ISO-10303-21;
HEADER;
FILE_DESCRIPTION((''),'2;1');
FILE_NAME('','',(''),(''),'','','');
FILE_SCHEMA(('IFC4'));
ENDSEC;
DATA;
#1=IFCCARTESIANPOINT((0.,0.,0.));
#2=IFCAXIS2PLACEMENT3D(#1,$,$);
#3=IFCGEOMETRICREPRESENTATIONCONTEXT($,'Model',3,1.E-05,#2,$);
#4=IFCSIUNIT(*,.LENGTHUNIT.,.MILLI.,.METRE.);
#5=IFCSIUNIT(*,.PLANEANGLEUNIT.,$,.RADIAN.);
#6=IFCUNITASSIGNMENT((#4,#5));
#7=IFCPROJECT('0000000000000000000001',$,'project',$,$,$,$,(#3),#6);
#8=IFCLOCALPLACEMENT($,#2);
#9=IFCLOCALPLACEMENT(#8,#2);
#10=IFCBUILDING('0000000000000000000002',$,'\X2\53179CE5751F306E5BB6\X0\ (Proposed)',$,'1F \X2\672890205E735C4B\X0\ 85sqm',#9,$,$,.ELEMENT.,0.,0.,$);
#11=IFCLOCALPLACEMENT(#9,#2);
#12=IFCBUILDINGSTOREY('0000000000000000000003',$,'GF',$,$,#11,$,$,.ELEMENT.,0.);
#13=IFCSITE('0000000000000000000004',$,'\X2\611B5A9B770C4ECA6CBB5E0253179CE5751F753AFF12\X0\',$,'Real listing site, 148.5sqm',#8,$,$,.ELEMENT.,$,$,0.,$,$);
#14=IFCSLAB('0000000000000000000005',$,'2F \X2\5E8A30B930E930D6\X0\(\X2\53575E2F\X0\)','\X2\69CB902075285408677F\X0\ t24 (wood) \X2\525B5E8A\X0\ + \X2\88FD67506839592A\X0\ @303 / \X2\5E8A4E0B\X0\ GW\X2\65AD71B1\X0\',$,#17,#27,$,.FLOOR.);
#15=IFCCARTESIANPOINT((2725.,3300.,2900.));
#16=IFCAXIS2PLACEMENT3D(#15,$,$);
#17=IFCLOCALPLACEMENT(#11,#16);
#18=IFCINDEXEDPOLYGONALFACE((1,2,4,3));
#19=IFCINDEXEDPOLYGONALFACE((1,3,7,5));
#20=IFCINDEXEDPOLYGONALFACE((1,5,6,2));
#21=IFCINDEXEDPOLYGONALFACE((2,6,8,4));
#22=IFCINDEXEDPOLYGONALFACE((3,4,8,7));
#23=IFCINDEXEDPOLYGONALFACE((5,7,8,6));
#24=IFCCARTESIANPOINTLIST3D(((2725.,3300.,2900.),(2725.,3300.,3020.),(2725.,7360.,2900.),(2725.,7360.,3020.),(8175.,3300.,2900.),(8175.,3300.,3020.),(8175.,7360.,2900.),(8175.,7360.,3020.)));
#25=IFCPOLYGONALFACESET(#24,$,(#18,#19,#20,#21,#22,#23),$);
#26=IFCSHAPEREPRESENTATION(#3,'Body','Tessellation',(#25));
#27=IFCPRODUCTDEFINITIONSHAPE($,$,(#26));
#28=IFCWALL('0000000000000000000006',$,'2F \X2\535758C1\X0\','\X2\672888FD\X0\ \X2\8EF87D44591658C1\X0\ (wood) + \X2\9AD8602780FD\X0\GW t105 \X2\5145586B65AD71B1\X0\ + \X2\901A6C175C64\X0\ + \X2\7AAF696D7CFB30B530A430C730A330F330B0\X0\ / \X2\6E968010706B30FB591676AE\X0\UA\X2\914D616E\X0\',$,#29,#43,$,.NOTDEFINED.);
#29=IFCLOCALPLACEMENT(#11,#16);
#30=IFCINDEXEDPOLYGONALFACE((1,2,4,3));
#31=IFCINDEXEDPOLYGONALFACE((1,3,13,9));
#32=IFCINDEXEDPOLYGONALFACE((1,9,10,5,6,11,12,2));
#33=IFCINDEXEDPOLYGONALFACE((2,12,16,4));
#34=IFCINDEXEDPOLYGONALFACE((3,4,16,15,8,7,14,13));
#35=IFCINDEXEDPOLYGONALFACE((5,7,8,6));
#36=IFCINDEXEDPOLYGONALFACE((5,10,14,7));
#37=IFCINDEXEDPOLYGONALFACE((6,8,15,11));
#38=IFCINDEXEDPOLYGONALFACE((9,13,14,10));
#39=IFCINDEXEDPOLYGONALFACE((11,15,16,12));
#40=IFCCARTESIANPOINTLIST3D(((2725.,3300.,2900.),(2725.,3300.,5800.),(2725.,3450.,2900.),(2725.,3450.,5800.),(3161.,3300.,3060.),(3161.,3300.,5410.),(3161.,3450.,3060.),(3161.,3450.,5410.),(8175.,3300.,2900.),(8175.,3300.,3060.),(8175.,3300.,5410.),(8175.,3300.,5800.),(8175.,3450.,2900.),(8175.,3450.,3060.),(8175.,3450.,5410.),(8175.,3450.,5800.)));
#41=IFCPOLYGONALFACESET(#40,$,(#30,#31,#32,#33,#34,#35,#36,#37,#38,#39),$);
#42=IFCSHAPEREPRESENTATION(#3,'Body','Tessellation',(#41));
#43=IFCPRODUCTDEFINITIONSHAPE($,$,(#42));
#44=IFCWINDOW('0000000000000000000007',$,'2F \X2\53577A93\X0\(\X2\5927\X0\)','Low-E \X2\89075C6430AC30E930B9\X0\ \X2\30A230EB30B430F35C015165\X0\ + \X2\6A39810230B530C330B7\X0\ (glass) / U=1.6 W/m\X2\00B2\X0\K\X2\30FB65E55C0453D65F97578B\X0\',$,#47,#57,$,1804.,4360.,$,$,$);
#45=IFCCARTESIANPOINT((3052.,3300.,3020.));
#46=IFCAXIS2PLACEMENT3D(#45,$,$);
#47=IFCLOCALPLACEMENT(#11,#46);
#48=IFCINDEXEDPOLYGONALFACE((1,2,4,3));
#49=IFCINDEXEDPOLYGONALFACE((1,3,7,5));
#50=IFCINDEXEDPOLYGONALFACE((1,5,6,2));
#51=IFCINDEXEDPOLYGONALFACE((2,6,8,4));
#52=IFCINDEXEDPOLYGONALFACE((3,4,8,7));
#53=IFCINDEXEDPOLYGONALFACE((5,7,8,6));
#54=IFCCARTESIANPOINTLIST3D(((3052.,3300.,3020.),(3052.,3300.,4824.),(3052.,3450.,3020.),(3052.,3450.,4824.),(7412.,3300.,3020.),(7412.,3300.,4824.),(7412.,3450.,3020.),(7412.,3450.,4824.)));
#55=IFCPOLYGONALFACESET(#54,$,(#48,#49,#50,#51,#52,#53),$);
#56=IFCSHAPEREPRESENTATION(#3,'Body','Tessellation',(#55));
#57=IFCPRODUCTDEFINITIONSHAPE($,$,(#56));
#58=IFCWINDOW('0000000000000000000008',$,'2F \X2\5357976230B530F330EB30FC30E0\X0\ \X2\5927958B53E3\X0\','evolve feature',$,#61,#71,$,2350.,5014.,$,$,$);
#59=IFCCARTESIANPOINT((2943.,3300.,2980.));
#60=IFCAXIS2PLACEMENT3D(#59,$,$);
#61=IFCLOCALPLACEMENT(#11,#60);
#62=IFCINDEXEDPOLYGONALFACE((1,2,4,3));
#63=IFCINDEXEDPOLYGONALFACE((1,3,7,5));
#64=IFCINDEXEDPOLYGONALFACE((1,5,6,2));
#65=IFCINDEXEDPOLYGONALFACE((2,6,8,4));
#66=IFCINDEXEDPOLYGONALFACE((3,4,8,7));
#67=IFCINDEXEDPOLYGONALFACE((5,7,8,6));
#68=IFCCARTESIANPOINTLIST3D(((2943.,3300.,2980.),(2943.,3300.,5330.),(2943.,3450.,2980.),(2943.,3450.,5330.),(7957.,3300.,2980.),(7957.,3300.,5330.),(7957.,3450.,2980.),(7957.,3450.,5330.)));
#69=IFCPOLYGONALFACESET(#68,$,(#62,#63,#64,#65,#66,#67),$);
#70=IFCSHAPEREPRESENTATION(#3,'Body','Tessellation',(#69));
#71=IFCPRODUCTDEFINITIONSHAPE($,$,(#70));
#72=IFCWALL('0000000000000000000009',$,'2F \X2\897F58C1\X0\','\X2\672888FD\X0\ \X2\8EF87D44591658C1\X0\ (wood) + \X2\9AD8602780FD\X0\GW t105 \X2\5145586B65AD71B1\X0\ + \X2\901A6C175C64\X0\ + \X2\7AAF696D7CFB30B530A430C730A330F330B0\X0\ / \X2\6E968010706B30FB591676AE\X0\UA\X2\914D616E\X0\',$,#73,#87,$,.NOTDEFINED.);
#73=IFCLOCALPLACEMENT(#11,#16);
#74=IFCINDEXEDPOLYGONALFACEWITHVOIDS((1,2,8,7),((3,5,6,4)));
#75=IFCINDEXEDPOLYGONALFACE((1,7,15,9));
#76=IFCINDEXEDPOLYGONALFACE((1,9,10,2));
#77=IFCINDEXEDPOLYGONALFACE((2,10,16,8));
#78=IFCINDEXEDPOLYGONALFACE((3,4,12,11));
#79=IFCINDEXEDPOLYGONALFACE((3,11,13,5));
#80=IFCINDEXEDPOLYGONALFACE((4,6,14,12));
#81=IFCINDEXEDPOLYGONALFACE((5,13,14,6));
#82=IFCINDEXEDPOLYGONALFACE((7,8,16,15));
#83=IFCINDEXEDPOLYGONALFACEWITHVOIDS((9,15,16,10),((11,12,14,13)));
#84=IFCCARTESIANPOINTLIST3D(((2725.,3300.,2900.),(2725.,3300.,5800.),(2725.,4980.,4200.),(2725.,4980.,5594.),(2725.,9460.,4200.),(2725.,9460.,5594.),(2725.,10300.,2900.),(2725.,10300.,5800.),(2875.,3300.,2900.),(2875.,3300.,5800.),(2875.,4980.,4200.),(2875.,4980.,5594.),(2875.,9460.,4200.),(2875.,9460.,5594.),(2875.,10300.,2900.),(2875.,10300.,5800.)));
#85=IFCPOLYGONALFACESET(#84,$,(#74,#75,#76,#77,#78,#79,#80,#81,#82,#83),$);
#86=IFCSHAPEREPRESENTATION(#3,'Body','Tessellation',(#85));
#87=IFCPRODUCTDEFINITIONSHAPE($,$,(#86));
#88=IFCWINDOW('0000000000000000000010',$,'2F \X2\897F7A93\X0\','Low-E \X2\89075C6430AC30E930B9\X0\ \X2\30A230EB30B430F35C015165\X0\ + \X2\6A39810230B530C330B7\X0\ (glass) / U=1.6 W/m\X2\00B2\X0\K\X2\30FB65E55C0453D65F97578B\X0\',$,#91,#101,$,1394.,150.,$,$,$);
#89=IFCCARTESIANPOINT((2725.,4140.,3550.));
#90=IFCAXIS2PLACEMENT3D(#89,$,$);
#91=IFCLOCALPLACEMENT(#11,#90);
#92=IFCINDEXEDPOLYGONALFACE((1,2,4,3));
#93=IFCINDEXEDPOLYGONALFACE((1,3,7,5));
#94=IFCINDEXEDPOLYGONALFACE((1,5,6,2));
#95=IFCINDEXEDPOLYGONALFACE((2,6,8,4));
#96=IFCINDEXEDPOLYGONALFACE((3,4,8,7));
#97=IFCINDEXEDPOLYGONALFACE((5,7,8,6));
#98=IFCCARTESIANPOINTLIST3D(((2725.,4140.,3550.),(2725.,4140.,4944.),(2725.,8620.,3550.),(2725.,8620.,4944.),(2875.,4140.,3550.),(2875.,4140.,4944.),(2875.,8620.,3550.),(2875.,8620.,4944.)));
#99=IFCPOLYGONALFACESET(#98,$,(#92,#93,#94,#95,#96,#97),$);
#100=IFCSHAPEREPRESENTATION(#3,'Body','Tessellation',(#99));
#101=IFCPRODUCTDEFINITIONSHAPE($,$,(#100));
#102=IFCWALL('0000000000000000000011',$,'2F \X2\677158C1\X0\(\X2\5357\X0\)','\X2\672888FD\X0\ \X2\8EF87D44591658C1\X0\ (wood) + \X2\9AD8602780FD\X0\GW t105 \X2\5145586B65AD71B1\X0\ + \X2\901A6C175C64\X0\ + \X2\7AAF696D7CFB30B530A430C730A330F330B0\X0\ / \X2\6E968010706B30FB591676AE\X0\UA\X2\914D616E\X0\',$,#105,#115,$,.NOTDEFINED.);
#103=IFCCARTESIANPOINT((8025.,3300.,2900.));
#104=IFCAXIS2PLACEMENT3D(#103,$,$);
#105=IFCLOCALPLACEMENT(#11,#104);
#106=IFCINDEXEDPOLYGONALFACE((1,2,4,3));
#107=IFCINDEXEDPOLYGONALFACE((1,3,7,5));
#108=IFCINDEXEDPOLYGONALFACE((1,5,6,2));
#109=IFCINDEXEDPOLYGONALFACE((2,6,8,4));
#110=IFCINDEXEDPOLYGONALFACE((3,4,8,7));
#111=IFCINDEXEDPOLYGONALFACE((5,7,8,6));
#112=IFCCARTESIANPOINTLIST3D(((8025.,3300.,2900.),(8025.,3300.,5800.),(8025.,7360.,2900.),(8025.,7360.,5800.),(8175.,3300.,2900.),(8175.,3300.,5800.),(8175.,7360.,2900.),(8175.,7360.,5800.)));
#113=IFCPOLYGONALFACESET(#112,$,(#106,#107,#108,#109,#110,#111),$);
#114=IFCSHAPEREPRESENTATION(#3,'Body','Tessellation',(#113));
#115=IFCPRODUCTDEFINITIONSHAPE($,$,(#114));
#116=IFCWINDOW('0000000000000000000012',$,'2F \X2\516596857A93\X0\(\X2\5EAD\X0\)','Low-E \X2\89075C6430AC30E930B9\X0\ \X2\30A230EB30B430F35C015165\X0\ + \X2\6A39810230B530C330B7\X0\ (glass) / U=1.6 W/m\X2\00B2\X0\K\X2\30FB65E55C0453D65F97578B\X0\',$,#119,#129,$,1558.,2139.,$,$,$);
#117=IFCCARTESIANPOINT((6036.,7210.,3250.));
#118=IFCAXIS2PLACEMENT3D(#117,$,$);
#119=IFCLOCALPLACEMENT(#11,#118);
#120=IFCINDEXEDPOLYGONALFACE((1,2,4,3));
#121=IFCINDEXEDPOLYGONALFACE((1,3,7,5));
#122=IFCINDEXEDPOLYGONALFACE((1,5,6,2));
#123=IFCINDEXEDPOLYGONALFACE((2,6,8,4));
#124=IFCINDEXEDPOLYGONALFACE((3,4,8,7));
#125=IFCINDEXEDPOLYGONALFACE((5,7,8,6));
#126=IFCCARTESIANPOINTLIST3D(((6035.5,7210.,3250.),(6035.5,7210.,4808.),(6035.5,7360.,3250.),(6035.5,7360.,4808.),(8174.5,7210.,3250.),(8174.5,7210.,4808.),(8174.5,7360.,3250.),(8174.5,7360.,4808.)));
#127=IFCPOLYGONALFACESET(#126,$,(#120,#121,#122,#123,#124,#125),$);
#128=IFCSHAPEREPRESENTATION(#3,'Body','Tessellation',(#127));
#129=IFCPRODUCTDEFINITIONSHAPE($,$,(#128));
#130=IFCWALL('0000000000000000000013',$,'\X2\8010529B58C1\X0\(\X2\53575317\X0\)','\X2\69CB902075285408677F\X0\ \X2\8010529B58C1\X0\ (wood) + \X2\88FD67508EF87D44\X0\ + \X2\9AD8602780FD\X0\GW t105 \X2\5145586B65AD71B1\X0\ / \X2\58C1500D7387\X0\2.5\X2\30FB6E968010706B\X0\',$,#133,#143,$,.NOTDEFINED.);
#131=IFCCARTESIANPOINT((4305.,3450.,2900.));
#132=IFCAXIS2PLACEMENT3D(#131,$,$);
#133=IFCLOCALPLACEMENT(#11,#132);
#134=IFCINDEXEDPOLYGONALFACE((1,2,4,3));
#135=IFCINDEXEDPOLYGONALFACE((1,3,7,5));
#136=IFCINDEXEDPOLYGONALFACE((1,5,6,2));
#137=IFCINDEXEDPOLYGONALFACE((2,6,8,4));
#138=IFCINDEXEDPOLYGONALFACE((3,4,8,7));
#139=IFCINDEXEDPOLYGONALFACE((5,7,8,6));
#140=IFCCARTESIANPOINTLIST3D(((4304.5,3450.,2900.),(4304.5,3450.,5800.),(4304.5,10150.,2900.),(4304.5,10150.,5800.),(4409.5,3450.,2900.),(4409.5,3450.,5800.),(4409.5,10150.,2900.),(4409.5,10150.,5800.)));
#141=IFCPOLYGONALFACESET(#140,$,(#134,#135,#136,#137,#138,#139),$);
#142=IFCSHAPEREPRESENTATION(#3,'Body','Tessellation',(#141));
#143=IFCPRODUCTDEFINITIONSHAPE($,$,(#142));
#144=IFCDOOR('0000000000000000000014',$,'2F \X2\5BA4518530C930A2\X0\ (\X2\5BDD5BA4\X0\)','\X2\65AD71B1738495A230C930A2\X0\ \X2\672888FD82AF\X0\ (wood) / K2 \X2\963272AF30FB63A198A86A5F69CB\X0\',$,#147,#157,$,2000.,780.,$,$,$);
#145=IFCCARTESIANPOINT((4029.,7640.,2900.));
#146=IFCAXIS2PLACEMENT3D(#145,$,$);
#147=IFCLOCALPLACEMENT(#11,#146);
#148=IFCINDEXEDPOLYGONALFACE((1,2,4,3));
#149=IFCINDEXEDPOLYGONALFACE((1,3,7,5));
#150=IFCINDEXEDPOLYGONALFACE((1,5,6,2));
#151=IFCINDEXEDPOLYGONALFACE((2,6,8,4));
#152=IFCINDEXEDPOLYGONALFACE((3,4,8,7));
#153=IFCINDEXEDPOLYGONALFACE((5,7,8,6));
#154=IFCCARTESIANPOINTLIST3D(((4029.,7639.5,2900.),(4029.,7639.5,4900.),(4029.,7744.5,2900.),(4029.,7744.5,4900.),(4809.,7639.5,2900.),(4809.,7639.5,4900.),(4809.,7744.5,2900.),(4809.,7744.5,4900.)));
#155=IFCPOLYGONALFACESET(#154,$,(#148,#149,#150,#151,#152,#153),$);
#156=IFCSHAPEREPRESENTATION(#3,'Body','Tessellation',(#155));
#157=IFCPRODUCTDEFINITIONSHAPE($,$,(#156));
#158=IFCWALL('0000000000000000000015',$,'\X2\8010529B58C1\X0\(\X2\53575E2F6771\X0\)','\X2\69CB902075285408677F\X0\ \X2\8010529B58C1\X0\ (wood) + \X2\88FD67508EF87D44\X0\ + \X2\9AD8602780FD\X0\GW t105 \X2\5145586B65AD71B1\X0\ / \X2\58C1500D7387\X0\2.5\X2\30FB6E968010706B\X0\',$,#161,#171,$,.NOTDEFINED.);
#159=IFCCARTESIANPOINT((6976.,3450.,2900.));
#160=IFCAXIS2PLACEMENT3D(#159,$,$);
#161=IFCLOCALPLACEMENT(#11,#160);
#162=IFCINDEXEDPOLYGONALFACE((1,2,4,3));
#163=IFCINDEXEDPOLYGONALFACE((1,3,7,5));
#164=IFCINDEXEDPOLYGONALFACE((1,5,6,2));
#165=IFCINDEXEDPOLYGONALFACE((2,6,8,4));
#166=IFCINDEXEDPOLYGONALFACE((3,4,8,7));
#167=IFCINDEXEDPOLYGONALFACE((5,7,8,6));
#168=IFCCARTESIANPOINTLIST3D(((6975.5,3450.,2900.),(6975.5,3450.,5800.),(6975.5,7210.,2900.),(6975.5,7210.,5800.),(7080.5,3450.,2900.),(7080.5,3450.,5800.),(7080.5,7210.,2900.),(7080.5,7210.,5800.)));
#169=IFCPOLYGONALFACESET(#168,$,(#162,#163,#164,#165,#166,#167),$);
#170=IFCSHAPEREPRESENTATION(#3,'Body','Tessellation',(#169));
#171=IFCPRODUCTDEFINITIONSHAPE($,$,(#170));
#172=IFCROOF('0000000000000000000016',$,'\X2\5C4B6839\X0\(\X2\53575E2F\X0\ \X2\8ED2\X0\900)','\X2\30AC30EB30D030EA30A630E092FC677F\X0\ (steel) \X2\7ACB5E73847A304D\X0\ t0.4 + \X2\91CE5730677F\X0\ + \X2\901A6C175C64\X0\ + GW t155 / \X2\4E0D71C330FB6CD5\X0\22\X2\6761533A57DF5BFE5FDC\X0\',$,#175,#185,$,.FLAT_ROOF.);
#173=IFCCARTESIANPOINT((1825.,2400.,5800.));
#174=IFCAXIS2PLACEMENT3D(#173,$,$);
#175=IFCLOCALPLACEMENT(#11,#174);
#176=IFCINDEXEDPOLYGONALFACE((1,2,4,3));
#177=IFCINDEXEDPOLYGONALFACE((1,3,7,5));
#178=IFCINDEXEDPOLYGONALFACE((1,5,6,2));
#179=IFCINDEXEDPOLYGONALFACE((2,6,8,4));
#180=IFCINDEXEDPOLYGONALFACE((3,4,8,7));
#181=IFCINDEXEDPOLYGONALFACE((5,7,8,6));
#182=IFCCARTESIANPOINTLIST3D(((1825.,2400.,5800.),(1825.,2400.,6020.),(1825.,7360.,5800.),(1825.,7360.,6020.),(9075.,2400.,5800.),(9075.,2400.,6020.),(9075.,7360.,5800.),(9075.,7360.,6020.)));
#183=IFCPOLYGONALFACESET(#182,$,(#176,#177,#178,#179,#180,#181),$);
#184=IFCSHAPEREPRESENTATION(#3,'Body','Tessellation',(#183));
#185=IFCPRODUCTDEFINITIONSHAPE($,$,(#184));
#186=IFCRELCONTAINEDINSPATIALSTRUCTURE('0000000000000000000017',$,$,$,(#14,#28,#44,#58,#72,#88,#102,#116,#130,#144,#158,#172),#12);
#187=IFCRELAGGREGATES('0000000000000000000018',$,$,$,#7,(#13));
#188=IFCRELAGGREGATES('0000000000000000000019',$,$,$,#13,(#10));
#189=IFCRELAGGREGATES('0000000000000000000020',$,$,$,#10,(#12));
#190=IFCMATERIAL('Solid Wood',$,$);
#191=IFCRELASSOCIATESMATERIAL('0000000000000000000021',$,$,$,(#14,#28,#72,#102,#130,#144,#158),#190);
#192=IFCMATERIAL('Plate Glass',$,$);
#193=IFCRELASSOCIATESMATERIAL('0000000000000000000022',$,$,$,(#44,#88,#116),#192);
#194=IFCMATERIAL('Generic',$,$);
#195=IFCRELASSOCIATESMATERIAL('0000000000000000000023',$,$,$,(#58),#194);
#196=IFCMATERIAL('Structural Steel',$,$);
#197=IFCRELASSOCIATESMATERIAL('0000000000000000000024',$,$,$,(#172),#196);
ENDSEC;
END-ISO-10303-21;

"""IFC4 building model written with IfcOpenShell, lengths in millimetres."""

from ifc_helpers import new_model, si_unit, frame, frame_2d, origin, place, context, project, spatial, rectangle, extrude, material, element, fill, save


model = new_model("IFC4")

# Units and contexts
model_context = context("Model", 3, precision=1e-05, world=origin())
ifc_project = project(units=[si_unit("LENGTHUNIT", "METRE", prefix="MILLI"), si_unit("PLANEANGLEUNIT", "RADIAN")], contexts=[model_context])

# Site, building, storey
site_placement = place(None, origin())
site = spatial("IfcSite", under=ifc_project, at=site_placement, Name="愛媛県今治市北鳥生町２", ObjectType="Real listing site, 148.5sqm", CompositionType="ELEMENT", RefElevation=0.0)
building_placement = place(site_placement, origin())
building = spatial("IfcBuilding", under=site, at=building_placement, Name="北鳥生の家 (Proposed)", ObjectType="1F 木造平屋 85sqm", CompositionType="ELEMENT", ElevationOfRefHeight=0.0, ElevationOfTerrain=0.0)
storey_placement = place(building_placement, origin())
storey = spatial("IfcBuildingStorey", under=building, at=storey_placement, Name="GF", CompositionType="ELEMENT", Elevation=0.0)

# Slab
ifc_material_1 = material(Name="Solid Wood")
slab_placement = place(storey_placement, frame((2725.0, 3300.0, 2900.0)))
element("IfcSlab", 1, at=slab_placement, inside=storey, material=ifc_material_1, Name="2F 床スラブ(南帯)", Description="構造用合板 t24 (wood) 剛床 + 製材根太 @303 / 床下 GW断熱", PredefinedType="FLOOR", context=model_context, shape_type="SweptSolid", body=[
    extrude(rectangle(XDim=5450.0, YDim=4060.0, at=frame_2d((2725.0, 2030.0))), frame((2725.0, 3300.0, 2900.0)), (0.0, 0.0, 1.0), 120.0),
])

# Wall, openings, windows
wall_1_placement = place(storey_placement, frame((2725.0, 3300.0, 2900.0)))
wall_1 = element("IfcWall", 2, at=wall_1_placement, inside=storey, material=ifc_material_1, Name="2F 南壁", Description="木製 軸組外壁 (wood) + 高性能GW t105 充填断熱 + 通気層 + 窯業系サイディング / 準耐火・外皮UA配慮", PredefinedType="NOTDEFINED", context=model_context, shape_type="SweptSolid", body=[
    extrude(rectangle(XDim=5450.0, YDim=150.0, at=frame_2d((2725.0, 75.0))), frame((2725.0, 3300.0, 2900.0)), (0.0, 0.0, 1.0), 2900.0),
])
opening_1_placement = place(storey_placement, frame((3052.0, 3300.0, 3020.0)))
opening_1 = element("IfcOpeningElement", 3, at=opening_1_placement, cuts=wall_1, PredefinedType="NOTDEFINED", context=model_context, shape_type="SweptSolid", body=[
    extrude(rectangle(XDim=4360.0, YDim=150.0, at=frame_2d((2180.0, 75.0))), frame((3052.0, 3300.0, 3020.0)), (0.0, 0.0, 1.0), 1804.0),
])
opening_2_placement = place(storey_placement, frame((2943.0, 3300.0, 2980.0)))
opening_2 = element("IfcOpeningElement", 4, at=opening_2_placement, cuts=wall_1, PredefinedType="NOTDEFINED", context=model_context, shape_type="SweptSolid", body=[
    extrude(rectangle(XDim=5014.0, YDim=150.0, at=frame_2d((2507.0, 75.0))), frame((2943.0, 3300.0, 2980.0)), (0.0, 0.0, 1.0), 2350.0),
])
ifc_material_2 = material(Name="Plate Glass")
window_1_placement = place(storey_placement, frame((3052.0, 3300.0, 3020.0)))
window_1 = element("IfcWindow", 5, at=window_1_placement, inside=storey, material=ifc_material_2, Name="2F 南窓(大)", Description="Low-E 複層ガラス アルゴン封入 + 樹脂サッシ (glass) / U=1.6 W/m²K・日射取得型", OverallHeight=1804.0, OverallWidth=4360.0, context=model_context, shape_type="SweptSolid", body=[
    extrude(rectangle(XDim=4360.0, YDim=150.0, at=frame_2d((2180.0, 75.0))), frame((3052.0, 3300.0, 3020.0)), (0.0, 0.0, 1.0), 1804.0),
])
fill(opening_1, window_1)
ifc_material_3 = material(Name="Generic")
window_2_placement = place(storey_placement, frame((2943.0, 3300.0, 2980.0)))
window_2 = element("IfcWindow", 6, at=window_2_placement, inside=storey, material=ifc_material_3, Name="2F 南面サンルーム 大開口", Description="evolve feature", OverallHeight=2350.0, OverallWidth=5014.0, context=model_context, shape_type="SweptSolid", body=[
    extrude(rectangle(XDim=5014.0, YDim=150.0, at=frame_2d((2507.0, 75.0))), frame((2943.0, 3300.0, 2980.0)), (0.0, 0.0, 1.0), 2350.0),
])
fill(opening_2, window_2)

# Walls, openings, windows
wall_2_placement = place(storey_placement, frame((2725.0, 3300.0, 2900.0)))
wall_2 = element("IfcWall", 7, at=wall_2_placement, inside=storey, material=ifc_material_1, Name="2F 西壁", Description="木製 軸組外壁 (wood) + 高性能GW t105 充填断熱 + 通気層 + 窯業系サイディング / 準耐火・外皮UA配慮", PredefinedType="NOTDEFINED", context=model_context, shape_type="SweptSolid", body=[
    extrude(rectangle(XDim=150.0, YDim=7000.0, at=frame_2d((75.0, 3500.0))), frame((2725.0, 3300.0, 2900.0)), (0.0, 0.0, 1.0), 2900.0),
])
opening_3_placement = place(storey_placement, frame((2725.0, 4140.0, 3550.0)))
opening_3 = element("IfcOpeningElement", 8, at=opening_3_placement, cuts=wall_2, PredefinedType="NOTDEFINED", context=model_context, shape_type="SweptSolid", body=[
    extrude(rectangle(XDim=150.0, YDim=4480.0, at=frame_2d((75.0, 2240.0))), frame((2725.0, 4140.0, 3550.0)), (0.0, 0.0, 1.0), 1394.0),
])
window_3_placement = place(storey_placement, frame((2725.0, 4140.0, 3550.0)))
window_3 = element("IfcWindow", 9, at=window_3_placement, inside=storey, material=ifc_material_2, Name="2F 西窓", Description="Low-E 複層ガラス アルゴン封入 + 樹脂サッシ (glass) / U=1.6 W/m²K・日射取得型", OverallHeight=1394.0, OverallWidth=150.0, context=model_context, shape_type="SweptSolid", body=[
    extrude(rectangle(XDim=150.0, YDim=4480.0, at=frame_2d((75.0, 2240.0))), frame((2725.0, 4140.0, 3550.0)), (0.0, 0.0, 1.0), 1394.0),
])
fill(opening_3, window_3)
wall_3_placement = place(storey_placement, frame((8025.0, 3300.0, 2900.0)))
wall_3 = element("IfcWall", 10, at=wall_3_placement, inside=storey, material=ifc_material_1, Name="2F 東壁(南)", Description="木製 軸組外壁 (wood) + 高性能GW t105 充填断熱 + 通気層 + 窯業系サイディング / 準耐火・外皮UA配慮", PredefinedType="NOTDEFINED", context=model_context, shape_type="SweptSolid", body=[
    extrude(rectangle(XDim=150.0, YDim=4060.0, at=frame_2d((75.0, 2030.0))), frame((8025.0, 3300.0, 2900.0)), (0.0, 0.0, 1.0), 2900.0),
])
opening_4_placement = place(storey_placement, frame((6036.0, 7210.0, 3250.0)))
opening_4 = element("IfcOpeningElement", 11, at=opening_4_placement, cuts=wall_3, PredefinedType="NOTDEFINED", context=model_context, shape_type="SweptSolid", body=[
    extrude(rectangle(XDim=2139.0, YDim=150.0, at=frame_2d((1069.0, 75.0))), frame((6036.0, 7210.0, 3250.0)), (0.0, 0.0, 1.0), 1558.0),
])
window_4_placement = place(storey_placement, frame((6036.0, 7210.0, 3250.0)))
window_4 = element("IfcWindow", 12, at=window_4_placement, inside=storey, material=ifc_material_2, Name="2F 入隅窓(庭)", Description="Low-E 複層ガラス アルゴン封入 + 樹脂サッシ (glass) / U=1.6 W/m²K・日射取得型", OverallHeight=1558.0, OverallWidth=2139.0, context=model_context, shape_type="SweptSolid", body=[
    extrude(rectangle(XDim=2139.0, YDim=150.0, at=frame_2d((1069.0, 75.0))), frame((6036.0, 7210.0, 3250.0)), (0.0, 0.0, 1.0), 1558.0),
])
fill(opening_4, window_4)

# Wall, opening, door
wall_4_placement = place(storey_placement, frame((4305.0, 3450.0, 2900.0)))
wall_4 = element("IfcWall", 13, at=wall_4_placement, inside=storey, material=ifc_material_1, Name="耐力壁(南北)", Description="構造用合板 耐力壁 (wood) + 製材軸組 + 高性能GW t105 充填断熱 / 壁倍率2.5・準耐火", PredefinedType="NOTDEFINED", context=model_context, shape_type="SweptSolid", body=[
    extrude(rectangle(XDim=105.0, YDim=6700.0, at=frame_2d((52.0, 3350.0))), frame((4305.0, 3450.0, 2900.0)), (0.0, 0.0, 1.0), 2900.0),
])
opening_5_placement = place(storey_placement, frame((4029.0, 7640.0, 2900.0)))
opening_5 = element("IfcOpeningElement", 14, at=opening_5_placement, cuts=wall_4, PredefinedType="NOTDEFINED", context=model_context, shape_type="SweptSolid", body=[
    extrude(rectangle(XDim=780.0, YDim=105.0, at=frame_2d((390.0, 52.0))), frame((4029.0, 7640.0, 2900.0)), (0.0, 0.0, 1.0), 2000.0),
])
door_placement = place(storey_placement, frame((4029.0, 7640.0, 2900.0)))
door = element("IfcDoor", 15, at=door_placement, inside=storey, material=ifc_material_1, Name="2F 室内ドア (寝室)", Description="断熱玄関ドア 木製芯 (wood) / K2 防犯・採風機構", OverallHeight=2000.0, OverallWidth=780.0, context=model_context, shape_type="SweptSolid", body=[
    extrude(rectangle(XDim=780.0, YDim=105.0, at=frame_2d((390.0, 52.0))), frame((4029.0, 7640.0, 2900.0)), (0.0, 0.0, 1.0), 2000.0),
])
fill(opening_5, door)

# Wall
wall_5_placement = place(storey_placement, frame((6976.0, 3450.0, 2900.0)))
element("IfcWall", 16, at=wall_5_placement, inside=storey, material=ifc_material_1, Name="耐力壁(南帯東)", Description="構造用合板 耐力壁 (wood) + 製材軸組 + 高性能GW t105 充填断熱 / 壁倍率2.5・準耐火", PredefinedType="NOTDEFINED", context=model_context, shape_type="SweptSolid", body=[
    extrude(rectangle(XDim=105.0, YDim=3760.0, at=frame_2d((52.0, 1880.0))), frame((6976.0, 3450.0, 2900.0)), (0.0, 0.0, 1.0), 2900.0),
])

# Roof
ifc_material_4 = material(Name="Structural Steel")
for number, where, name in (
    (17, (1825.0, 2400.0, 5800.0), "屋根(南帯 軒900)"),
):
    element("IfcRoof", number, at=place(storey_placement, frame(where)), inside=storey, material=ifc_material_4, Name=name, Description="ガルバリウム鋼板 (steel) 立平葺き t0.4 + 野地板 + 通気層 + GW t155 / 不燃・法22条区域対応", PredefinedType="FLAT_ROOF", context=model_context, shape_type="SweptSolid", body=[
        extrude(rectangle(XDim=7250.0, YDim=4960.0, at=frame_2d((3625.0, 2480.0))), frame((1825.0, 2400.0, 5800.0)), (0.0, 0.0, 1.0), 220.0),
    ])

save(model, "model.ifc")
